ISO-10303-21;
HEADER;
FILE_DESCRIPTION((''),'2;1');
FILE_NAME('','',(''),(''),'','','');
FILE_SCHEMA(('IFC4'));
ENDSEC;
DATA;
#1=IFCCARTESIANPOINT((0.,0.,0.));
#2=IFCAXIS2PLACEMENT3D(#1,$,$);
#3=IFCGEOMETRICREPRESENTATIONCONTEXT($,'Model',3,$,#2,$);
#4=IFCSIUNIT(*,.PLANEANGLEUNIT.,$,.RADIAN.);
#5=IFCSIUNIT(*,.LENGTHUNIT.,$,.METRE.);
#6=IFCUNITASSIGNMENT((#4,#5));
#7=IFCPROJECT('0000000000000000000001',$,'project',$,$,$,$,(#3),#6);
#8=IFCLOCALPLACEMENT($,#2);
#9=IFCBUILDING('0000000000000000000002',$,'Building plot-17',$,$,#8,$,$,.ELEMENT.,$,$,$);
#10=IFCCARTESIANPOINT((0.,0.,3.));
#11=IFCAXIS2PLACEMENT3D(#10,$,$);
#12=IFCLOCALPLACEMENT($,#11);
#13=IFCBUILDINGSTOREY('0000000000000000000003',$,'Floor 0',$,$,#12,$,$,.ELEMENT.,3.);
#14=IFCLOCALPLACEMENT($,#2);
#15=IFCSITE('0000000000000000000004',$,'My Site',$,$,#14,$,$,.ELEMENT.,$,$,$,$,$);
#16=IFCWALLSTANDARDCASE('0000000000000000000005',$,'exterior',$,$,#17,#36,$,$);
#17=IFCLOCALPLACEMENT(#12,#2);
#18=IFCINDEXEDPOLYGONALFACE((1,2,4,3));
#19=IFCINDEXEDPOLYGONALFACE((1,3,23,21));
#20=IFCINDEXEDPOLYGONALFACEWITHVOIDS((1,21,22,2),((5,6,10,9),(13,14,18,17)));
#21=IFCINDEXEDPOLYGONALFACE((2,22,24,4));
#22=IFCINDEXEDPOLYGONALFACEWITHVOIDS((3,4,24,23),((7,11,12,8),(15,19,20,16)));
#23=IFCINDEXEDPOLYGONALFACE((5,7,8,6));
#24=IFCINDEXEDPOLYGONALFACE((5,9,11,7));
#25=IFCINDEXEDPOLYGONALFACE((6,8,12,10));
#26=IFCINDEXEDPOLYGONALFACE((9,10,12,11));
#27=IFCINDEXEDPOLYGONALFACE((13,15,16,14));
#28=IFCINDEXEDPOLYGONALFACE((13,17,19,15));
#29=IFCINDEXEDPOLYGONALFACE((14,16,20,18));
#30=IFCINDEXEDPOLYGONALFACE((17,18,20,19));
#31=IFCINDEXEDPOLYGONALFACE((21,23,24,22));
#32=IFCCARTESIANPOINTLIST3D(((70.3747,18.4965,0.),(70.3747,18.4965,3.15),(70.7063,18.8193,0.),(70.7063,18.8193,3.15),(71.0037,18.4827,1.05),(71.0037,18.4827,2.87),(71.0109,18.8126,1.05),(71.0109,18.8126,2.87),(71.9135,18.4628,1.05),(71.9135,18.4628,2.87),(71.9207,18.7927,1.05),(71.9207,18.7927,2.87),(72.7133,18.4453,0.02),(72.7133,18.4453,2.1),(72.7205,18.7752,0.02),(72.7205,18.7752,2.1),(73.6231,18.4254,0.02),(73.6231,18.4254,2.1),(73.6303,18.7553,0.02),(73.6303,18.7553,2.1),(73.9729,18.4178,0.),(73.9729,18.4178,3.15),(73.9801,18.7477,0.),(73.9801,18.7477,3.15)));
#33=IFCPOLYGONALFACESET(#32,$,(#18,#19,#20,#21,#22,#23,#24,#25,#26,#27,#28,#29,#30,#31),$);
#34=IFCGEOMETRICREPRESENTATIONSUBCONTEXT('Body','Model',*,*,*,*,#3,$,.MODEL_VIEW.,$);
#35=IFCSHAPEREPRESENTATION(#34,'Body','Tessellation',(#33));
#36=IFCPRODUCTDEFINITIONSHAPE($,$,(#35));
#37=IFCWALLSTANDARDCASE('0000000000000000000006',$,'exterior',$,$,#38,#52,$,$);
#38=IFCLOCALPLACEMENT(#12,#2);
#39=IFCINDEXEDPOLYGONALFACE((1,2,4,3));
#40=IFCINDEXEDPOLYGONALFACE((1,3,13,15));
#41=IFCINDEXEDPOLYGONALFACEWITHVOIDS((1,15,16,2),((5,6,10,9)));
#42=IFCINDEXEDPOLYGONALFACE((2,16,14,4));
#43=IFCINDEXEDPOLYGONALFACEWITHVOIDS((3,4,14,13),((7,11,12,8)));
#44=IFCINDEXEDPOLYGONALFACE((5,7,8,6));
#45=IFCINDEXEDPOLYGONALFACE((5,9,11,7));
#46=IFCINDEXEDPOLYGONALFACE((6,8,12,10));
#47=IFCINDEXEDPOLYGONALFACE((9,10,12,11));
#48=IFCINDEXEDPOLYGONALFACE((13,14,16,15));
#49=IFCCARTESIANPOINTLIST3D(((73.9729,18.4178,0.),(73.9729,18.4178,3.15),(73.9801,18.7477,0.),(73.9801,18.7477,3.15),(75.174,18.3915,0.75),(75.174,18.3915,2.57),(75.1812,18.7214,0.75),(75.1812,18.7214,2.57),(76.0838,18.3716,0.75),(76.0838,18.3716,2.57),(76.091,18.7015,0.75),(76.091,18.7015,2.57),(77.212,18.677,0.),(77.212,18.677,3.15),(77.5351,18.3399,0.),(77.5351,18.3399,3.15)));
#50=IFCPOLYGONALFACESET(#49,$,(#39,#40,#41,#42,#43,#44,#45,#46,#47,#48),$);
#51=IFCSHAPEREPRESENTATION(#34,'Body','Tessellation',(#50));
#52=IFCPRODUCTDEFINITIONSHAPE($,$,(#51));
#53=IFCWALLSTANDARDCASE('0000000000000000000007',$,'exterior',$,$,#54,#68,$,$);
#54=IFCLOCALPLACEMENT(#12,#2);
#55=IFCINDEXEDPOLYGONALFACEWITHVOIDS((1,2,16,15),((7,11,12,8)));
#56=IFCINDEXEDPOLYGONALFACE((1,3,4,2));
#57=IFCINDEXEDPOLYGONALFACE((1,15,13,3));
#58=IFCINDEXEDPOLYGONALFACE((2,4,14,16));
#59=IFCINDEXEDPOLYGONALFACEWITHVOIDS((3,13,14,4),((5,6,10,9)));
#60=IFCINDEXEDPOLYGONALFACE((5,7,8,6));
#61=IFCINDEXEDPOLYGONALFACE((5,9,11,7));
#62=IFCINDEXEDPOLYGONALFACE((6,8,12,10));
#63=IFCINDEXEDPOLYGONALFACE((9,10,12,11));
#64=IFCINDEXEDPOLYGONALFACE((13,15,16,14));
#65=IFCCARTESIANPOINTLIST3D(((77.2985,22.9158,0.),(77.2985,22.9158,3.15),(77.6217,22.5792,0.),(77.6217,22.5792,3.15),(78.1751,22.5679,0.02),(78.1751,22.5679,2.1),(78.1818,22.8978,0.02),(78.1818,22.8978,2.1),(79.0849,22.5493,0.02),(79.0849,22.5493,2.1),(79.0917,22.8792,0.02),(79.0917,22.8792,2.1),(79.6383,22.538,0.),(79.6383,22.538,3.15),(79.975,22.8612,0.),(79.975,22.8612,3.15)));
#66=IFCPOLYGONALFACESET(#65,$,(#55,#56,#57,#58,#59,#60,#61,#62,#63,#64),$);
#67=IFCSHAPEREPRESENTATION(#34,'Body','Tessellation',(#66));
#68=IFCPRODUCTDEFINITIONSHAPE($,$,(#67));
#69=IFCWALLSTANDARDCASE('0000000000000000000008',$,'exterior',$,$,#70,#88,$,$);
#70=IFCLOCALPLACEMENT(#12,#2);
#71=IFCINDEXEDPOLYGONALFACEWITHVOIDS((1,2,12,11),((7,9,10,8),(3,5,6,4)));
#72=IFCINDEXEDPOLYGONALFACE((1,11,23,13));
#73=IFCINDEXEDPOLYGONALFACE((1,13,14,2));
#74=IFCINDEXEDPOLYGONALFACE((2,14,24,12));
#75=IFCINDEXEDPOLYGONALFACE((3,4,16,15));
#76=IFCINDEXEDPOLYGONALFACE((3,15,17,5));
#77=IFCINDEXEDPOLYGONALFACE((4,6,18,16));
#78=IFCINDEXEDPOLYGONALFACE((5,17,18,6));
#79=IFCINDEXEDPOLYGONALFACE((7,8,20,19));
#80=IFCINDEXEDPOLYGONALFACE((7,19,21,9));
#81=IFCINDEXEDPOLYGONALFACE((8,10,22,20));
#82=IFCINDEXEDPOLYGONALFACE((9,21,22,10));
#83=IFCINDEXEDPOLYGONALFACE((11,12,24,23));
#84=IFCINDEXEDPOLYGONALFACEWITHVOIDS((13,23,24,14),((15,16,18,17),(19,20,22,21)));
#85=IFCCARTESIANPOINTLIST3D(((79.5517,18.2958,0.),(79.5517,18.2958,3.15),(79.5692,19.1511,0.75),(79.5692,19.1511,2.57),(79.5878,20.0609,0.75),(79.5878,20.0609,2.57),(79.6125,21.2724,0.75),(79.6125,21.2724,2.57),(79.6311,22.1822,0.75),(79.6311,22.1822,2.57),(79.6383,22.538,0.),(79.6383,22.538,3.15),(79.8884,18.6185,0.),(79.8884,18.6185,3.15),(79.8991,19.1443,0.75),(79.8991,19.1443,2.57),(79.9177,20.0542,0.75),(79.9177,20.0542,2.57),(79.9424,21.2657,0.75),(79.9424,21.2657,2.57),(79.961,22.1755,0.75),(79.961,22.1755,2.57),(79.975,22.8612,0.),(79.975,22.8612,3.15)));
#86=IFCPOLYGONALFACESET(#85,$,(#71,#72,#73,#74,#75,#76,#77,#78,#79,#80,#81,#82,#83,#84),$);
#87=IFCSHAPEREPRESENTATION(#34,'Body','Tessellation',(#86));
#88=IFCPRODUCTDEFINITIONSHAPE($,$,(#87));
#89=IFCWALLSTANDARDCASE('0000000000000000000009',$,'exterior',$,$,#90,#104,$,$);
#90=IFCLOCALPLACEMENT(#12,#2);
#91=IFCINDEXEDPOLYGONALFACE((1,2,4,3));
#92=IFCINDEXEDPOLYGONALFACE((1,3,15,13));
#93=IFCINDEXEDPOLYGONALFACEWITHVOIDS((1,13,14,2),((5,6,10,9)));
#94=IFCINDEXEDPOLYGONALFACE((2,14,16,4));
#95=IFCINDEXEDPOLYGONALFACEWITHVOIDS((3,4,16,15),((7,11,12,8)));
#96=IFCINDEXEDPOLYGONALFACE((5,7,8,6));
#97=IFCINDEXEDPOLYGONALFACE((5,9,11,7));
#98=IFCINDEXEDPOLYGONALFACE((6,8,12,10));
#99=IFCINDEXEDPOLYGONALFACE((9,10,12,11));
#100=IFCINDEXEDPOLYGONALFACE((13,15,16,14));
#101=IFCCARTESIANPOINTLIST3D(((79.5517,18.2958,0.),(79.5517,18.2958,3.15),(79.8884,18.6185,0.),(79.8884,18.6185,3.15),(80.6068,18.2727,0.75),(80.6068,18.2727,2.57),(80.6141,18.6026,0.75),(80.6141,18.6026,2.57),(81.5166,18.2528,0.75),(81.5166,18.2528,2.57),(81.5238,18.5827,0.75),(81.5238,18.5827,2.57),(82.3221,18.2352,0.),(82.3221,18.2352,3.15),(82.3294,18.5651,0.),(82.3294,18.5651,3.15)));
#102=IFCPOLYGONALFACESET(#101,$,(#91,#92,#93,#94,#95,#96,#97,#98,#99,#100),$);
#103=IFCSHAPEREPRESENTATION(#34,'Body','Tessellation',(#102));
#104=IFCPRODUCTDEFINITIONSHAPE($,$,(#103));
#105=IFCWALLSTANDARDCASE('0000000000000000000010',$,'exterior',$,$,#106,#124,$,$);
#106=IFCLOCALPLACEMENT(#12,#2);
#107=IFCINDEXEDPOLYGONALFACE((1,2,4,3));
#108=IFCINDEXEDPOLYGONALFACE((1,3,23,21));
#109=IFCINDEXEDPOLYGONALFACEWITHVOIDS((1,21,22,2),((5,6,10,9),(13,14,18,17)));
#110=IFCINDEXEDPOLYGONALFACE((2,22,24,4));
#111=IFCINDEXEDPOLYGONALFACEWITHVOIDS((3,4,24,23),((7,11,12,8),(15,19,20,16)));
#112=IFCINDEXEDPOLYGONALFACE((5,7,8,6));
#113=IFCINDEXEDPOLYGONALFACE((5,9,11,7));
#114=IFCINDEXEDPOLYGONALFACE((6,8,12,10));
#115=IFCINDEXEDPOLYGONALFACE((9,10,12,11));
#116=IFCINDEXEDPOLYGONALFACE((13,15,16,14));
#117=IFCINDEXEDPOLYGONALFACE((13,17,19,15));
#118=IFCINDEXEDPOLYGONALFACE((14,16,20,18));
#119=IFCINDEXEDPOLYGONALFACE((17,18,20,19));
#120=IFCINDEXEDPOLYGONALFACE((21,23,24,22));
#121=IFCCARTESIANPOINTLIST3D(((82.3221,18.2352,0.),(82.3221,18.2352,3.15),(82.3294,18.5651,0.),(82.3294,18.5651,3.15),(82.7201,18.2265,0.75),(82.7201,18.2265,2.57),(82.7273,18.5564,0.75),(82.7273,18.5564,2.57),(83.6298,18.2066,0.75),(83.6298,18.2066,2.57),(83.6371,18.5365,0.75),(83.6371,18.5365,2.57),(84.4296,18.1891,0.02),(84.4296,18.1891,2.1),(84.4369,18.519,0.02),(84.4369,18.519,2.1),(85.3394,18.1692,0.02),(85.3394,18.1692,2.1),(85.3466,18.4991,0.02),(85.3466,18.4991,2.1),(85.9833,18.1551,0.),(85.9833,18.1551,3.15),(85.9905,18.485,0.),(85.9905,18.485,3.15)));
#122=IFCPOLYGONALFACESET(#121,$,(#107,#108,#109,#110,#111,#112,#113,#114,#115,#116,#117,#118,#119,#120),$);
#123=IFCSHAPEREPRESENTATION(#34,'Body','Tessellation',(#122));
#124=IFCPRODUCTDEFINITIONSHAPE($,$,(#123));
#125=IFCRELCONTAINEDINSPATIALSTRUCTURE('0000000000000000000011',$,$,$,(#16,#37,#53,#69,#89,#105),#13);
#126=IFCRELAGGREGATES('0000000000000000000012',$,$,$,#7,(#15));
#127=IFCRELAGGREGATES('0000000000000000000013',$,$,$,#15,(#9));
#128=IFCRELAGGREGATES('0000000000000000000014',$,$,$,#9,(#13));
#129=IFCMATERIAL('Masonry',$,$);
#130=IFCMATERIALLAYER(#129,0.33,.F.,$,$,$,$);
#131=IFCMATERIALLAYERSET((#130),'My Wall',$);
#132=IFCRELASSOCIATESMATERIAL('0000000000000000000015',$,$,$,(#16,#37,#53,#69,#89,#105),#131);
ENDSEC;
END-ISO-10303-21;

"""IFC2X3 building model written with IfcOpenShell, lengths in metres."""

from ifc_helpers import new_model, si_unit, frame, origin, place, context, subcontext, project, spatial, polyline, outline, extrude, material, layer, layer_set, layer_usage, element, save


model = new_model("IFC2X3")

# Units and contexts
model_context = context("Model", 3, world=origin())
body_context = subcontext(model_context, "Body", "Model", "MODEL_VIEW")
ifc_project = project(units=[si_unit("PLANEANGLEUNIT", "RADIAN"), si_unit("LENGTHUNIT", "METRE")], contexts=[model_context])

# Site, building, storey
site_placement = place(None, origin())
site = spatial("IfcSite", under=ifc_project, at=site_placement, Name="My Site", CompositionType="ELEMENT")
building_placement = place(None, origin())
building = spatial("IfcBuilding", under=site, at=building_placement, Name="Building plot-17", CompositionType="ELEMENT")
storey_placement = place(None, frame((0.0, 0.0, 3.0)))
storey = spatial("IfcBuildingStorey", under=building, at=storey_placement, Name="Floor 0", CompositionType="ELEMENT", Elevation=3.0)

# Shared definitions
ifc_material = material(Name="Masonry")
ifc_layer = layer(ifc_material, 0.33, ventilated=False)
ifc_layer_set = layer_set([ifc_layer], Name="My Wall")
ifc_layer_usage = layer_usage(ifc_layer_set, "AXIS2", "NEGATIVE", 0.08)

# Wall, openings
wall_1_placement = place(storey_placement, origin())
wall_1 = element("IfcWallStandardCase", 1, at=wall_1_placement, inside=storey, material=ifc_layer_usage, Name="exterior", context=body_context, shape_type="SweptSolid", body=[
    extrude(outline(polyline([(70.7063, 18.8193), (70.3747, 18.4965), (73.9729, 18.4178), (73.9801, 18.7477), (70.7063, 18.8193)])), origin(), (0.0, 0.0, 1.0), 3.15),
])
opening_1_placement = place(storey_placement, frame((0.0, 0.0, 1.05)))
element("IfcOpeningElement", 2, at=opening_1_placement, cuts=wall_1, ObjectType="Opening", context=body_context, shape_type="SweptSolid", body=[
    extrude(outline(polyline([(71.0037, 18.4827), (71.9135, 18.4628), (71.9207, 18.7927), (71.0109, 18.8126), (71.0037, 18.4827)])), origin(), (0.0, 0.0, 1.0), 1.82),
])
opening_2_placement = place(storey_placement, frame((0.0, 0.0, 0.02)))
element("IfcOpeningElement", 3, at=opening_2_placement, cuts=wall_1, ObjectType="Opening", context=body_context, shape_type="SweptSolid", body=[
    extrude(outline(polyline([(72.7133, 18.4453), (73.6231, 18.4254), (73.6303, 18.7553), (72.7205, 18.7752), (72.7133, 18.4453)])), origin(), (0.0, 0.0, 1.0), 2.08),
])

# Wall, opening
wall_2_placement = place(storey_placement, origin())
wall_2 = element("IfcWallStandardCase", 4, at=wall_2_placement, inside=storey, material=ifc_layer_usage, Name="exterior", context=body_context, shape_type="SweptSolid", body=[
    extrude(outline(polyline([(73.9801, 18.7477), (73.9729, 18.4178), (77.5351, 18.3399), (77.212, 18.677), (73.9801, 18.7477)])), origin(), (0.0, 0.0, 1.0), 3.15),
])
opening_3_placement = place(storey_placement, frame((0.0, 0.0, 0.75)))
element("IfcOpeningElement", 5, at=opening_3_placement, cuts=wall_2, ObjectType="Opening", context=body_context, shape_type="SweptSolid", body=[
    extrude(outline(polyline([(75.174, 18.3915), (76.0838, 18.3716), (76.091, 18.7015), (75.1812, 18.7214), (75.174, 18.3915)])), origin(), (0.0, 0.0, 1.0), 1.82),
])

# Wall, opening
wall_3_placement = place(storey_placement, origin())
wall_3 = element("IfcWallStandardCase", 6, at=wall_3_placement, inside=storey, material=ifc_layer_usage, Name="exterior", context=body_context, shape_type="SweptSolid", body=[
    extrude(outline(polyline([(77.2985, 22.9158), (77.6217, 22.5792), (79.6383, 22.538), (79.975, 22.8612), (77.2985, 22.9158)])), origin(), (0.0, 0.0, 1.0), 3.15),
])
opening_4_placement = place(storey_placement, frame((0.0, 0.0, 0.02)))
element("IfcOpeningElement", 7, at=opening_4_placement, cuts=wall_3, ObjectType="Opening", context=body_context, shape_type="SweptSolid", body=[
    extrude(outline(polyline([(78.1751, 22.5679), (79.0849, 22.5493), (79.0917, 22.8792), (78.1818, 22.8978), (78.1751, 22.5679)])), origin(), (0.0, 0.0, 1.0), 2.08),
])

# Wall, openings
wall_4_placement = place(storey_placement, origin())
wall_4 = element("IfcWallStandardCase", 8, at=wall_4_placement, inside=storey, material=ifc_layer_usage, Name="exterior", context=body_context, shape_type="SweptSolid", body=[
    extrude(outline(polyline([(79.975, 22.8612), (79.6383, 22.538), (79.5517, 18.2958), (79.8884, 18.6185), (79.975, 22.8612)])), origin(), (0.0, 0.0, 1.0), 3.15),
])
opening_5_placement = place(storey_placement, frame((0.0, 0.0, 0.75)))
element("IfcOpeningElement", 9, at=opening_5_placement, cuts=wall_4, ObjectType="Opening", context=body_context, shape_type="SweptSolid", body=[
    extrude(outline(polyline([(79.6311, 22.1822), (79.6125, 21.2724), (79.9424, 21.2657), (79.961, 22.1755), (79.6311, 22.1822)])), origin(), (0.0, 0.0, 1.0), 1.82),
])
opening_6_placement = place(storey_placement, frame((0.0, 0.0, 0.75)))
element("IfcOpeningElement", 10, at=opening_6_placement, cuts=wall_4, ObjectType="Opening", context=body_context, shape_type="SweptSolid", body=[
    extrude(outline(polyline([(79.5878, 20.0609), (79.5692, 19.1511), (79.8991, 19.1443), (79.9177, 20.0542), (79.5878, 20.0609)])), origin(), (0.0, 0.0, 1.0), 1.82),
])

# Wall, opening
wall_5_placement = place(storey_placement, origin())
wall_5 = element("IfcWallStandardCase", 11, at=wall_5_placement, inside=storey, material=ifc_layer_usage, Name="exterior", context=body_context, shape_type="SweptSolid", body=[
    extrude(outline(polyline([(79.8884, 18.6185), (79.5517, 18.2958), (82.3221, 18.2352), (82.3294, 18.5651), (79.8884, 18.6185)])), origin(), (0.0, 0.0, 1.0), 3.15),
])
opening_7_placement = place(storey_placement, frame((0.0, 0.0, 0.75)))
element("IfcOpeningElement", 12, at=opening_7_placement, cuts=wall_5, ObjectType="Opening", context=body_context, shape_type="SweptSolid", body=[
    extrude(outline(polyline([(80.6068, 18.2727), (81.5166, 18.2528), (81.5238, 18.5827), (80.6141, 18.6026), (80.6068, 18.2727)])), origin(), (0.0, 0.0, 1.0), 1.82),
])

# Wall, openings
wall_6_placement = place(storey_placement, origin())
wall_6 = element("IfcWallStandardCase", 13, at=wall_6_placement, inside=storey, material=ifc_layer_usage, Name="exterior", context=body_context, shape_type="SweptSolid", body=[
    extrude(outline(polyline([(82.3294, 18.5651), (82.3221, 18.2352), (85.9833, 18.1551), (85.9905, 18.485), (82.3294, 18.5651)])), origin(), (0.0, 0.0, 1.0), 3.15),
])
opening_8_placement = place(storey_placement, frame((0.0, 0.0, 0.75)))
element("IfcOpeningElement", 14, at=opening_8_placement, cuts=wall_6, ObjectType="Opening", context=body_context, shape_type="SweptSolid", body=[
    extrude(outline(polyline([(82.7201, 18.2265), (83.6298, 18.2066), (83.6371, 18.5365), (82.7273, 18.5564), (82.7201, 18.2265)])), origin(), (0.0, 0.0, 1.0), 1.82),
])
opening_9_placement = place(storey_placement, frame((0.0, 0.0, 0.02)))
element("IfcOpeningElement", 15, at=opening_9_placement, cuts=wall_6, ObjectType="Opening", context=body_context, shape_type="SweptSolid", body=[
    extrude(outline(polyline([(84.4296, 18.1891), (85.3394, 18.1692), (85.3466, 18.4991), (84.4369, 18.519), (84.4296, 18.1891)])), origin(), (0.0, 0.0, 1.0), 2.08),
])

save(model, "model.ifc")
